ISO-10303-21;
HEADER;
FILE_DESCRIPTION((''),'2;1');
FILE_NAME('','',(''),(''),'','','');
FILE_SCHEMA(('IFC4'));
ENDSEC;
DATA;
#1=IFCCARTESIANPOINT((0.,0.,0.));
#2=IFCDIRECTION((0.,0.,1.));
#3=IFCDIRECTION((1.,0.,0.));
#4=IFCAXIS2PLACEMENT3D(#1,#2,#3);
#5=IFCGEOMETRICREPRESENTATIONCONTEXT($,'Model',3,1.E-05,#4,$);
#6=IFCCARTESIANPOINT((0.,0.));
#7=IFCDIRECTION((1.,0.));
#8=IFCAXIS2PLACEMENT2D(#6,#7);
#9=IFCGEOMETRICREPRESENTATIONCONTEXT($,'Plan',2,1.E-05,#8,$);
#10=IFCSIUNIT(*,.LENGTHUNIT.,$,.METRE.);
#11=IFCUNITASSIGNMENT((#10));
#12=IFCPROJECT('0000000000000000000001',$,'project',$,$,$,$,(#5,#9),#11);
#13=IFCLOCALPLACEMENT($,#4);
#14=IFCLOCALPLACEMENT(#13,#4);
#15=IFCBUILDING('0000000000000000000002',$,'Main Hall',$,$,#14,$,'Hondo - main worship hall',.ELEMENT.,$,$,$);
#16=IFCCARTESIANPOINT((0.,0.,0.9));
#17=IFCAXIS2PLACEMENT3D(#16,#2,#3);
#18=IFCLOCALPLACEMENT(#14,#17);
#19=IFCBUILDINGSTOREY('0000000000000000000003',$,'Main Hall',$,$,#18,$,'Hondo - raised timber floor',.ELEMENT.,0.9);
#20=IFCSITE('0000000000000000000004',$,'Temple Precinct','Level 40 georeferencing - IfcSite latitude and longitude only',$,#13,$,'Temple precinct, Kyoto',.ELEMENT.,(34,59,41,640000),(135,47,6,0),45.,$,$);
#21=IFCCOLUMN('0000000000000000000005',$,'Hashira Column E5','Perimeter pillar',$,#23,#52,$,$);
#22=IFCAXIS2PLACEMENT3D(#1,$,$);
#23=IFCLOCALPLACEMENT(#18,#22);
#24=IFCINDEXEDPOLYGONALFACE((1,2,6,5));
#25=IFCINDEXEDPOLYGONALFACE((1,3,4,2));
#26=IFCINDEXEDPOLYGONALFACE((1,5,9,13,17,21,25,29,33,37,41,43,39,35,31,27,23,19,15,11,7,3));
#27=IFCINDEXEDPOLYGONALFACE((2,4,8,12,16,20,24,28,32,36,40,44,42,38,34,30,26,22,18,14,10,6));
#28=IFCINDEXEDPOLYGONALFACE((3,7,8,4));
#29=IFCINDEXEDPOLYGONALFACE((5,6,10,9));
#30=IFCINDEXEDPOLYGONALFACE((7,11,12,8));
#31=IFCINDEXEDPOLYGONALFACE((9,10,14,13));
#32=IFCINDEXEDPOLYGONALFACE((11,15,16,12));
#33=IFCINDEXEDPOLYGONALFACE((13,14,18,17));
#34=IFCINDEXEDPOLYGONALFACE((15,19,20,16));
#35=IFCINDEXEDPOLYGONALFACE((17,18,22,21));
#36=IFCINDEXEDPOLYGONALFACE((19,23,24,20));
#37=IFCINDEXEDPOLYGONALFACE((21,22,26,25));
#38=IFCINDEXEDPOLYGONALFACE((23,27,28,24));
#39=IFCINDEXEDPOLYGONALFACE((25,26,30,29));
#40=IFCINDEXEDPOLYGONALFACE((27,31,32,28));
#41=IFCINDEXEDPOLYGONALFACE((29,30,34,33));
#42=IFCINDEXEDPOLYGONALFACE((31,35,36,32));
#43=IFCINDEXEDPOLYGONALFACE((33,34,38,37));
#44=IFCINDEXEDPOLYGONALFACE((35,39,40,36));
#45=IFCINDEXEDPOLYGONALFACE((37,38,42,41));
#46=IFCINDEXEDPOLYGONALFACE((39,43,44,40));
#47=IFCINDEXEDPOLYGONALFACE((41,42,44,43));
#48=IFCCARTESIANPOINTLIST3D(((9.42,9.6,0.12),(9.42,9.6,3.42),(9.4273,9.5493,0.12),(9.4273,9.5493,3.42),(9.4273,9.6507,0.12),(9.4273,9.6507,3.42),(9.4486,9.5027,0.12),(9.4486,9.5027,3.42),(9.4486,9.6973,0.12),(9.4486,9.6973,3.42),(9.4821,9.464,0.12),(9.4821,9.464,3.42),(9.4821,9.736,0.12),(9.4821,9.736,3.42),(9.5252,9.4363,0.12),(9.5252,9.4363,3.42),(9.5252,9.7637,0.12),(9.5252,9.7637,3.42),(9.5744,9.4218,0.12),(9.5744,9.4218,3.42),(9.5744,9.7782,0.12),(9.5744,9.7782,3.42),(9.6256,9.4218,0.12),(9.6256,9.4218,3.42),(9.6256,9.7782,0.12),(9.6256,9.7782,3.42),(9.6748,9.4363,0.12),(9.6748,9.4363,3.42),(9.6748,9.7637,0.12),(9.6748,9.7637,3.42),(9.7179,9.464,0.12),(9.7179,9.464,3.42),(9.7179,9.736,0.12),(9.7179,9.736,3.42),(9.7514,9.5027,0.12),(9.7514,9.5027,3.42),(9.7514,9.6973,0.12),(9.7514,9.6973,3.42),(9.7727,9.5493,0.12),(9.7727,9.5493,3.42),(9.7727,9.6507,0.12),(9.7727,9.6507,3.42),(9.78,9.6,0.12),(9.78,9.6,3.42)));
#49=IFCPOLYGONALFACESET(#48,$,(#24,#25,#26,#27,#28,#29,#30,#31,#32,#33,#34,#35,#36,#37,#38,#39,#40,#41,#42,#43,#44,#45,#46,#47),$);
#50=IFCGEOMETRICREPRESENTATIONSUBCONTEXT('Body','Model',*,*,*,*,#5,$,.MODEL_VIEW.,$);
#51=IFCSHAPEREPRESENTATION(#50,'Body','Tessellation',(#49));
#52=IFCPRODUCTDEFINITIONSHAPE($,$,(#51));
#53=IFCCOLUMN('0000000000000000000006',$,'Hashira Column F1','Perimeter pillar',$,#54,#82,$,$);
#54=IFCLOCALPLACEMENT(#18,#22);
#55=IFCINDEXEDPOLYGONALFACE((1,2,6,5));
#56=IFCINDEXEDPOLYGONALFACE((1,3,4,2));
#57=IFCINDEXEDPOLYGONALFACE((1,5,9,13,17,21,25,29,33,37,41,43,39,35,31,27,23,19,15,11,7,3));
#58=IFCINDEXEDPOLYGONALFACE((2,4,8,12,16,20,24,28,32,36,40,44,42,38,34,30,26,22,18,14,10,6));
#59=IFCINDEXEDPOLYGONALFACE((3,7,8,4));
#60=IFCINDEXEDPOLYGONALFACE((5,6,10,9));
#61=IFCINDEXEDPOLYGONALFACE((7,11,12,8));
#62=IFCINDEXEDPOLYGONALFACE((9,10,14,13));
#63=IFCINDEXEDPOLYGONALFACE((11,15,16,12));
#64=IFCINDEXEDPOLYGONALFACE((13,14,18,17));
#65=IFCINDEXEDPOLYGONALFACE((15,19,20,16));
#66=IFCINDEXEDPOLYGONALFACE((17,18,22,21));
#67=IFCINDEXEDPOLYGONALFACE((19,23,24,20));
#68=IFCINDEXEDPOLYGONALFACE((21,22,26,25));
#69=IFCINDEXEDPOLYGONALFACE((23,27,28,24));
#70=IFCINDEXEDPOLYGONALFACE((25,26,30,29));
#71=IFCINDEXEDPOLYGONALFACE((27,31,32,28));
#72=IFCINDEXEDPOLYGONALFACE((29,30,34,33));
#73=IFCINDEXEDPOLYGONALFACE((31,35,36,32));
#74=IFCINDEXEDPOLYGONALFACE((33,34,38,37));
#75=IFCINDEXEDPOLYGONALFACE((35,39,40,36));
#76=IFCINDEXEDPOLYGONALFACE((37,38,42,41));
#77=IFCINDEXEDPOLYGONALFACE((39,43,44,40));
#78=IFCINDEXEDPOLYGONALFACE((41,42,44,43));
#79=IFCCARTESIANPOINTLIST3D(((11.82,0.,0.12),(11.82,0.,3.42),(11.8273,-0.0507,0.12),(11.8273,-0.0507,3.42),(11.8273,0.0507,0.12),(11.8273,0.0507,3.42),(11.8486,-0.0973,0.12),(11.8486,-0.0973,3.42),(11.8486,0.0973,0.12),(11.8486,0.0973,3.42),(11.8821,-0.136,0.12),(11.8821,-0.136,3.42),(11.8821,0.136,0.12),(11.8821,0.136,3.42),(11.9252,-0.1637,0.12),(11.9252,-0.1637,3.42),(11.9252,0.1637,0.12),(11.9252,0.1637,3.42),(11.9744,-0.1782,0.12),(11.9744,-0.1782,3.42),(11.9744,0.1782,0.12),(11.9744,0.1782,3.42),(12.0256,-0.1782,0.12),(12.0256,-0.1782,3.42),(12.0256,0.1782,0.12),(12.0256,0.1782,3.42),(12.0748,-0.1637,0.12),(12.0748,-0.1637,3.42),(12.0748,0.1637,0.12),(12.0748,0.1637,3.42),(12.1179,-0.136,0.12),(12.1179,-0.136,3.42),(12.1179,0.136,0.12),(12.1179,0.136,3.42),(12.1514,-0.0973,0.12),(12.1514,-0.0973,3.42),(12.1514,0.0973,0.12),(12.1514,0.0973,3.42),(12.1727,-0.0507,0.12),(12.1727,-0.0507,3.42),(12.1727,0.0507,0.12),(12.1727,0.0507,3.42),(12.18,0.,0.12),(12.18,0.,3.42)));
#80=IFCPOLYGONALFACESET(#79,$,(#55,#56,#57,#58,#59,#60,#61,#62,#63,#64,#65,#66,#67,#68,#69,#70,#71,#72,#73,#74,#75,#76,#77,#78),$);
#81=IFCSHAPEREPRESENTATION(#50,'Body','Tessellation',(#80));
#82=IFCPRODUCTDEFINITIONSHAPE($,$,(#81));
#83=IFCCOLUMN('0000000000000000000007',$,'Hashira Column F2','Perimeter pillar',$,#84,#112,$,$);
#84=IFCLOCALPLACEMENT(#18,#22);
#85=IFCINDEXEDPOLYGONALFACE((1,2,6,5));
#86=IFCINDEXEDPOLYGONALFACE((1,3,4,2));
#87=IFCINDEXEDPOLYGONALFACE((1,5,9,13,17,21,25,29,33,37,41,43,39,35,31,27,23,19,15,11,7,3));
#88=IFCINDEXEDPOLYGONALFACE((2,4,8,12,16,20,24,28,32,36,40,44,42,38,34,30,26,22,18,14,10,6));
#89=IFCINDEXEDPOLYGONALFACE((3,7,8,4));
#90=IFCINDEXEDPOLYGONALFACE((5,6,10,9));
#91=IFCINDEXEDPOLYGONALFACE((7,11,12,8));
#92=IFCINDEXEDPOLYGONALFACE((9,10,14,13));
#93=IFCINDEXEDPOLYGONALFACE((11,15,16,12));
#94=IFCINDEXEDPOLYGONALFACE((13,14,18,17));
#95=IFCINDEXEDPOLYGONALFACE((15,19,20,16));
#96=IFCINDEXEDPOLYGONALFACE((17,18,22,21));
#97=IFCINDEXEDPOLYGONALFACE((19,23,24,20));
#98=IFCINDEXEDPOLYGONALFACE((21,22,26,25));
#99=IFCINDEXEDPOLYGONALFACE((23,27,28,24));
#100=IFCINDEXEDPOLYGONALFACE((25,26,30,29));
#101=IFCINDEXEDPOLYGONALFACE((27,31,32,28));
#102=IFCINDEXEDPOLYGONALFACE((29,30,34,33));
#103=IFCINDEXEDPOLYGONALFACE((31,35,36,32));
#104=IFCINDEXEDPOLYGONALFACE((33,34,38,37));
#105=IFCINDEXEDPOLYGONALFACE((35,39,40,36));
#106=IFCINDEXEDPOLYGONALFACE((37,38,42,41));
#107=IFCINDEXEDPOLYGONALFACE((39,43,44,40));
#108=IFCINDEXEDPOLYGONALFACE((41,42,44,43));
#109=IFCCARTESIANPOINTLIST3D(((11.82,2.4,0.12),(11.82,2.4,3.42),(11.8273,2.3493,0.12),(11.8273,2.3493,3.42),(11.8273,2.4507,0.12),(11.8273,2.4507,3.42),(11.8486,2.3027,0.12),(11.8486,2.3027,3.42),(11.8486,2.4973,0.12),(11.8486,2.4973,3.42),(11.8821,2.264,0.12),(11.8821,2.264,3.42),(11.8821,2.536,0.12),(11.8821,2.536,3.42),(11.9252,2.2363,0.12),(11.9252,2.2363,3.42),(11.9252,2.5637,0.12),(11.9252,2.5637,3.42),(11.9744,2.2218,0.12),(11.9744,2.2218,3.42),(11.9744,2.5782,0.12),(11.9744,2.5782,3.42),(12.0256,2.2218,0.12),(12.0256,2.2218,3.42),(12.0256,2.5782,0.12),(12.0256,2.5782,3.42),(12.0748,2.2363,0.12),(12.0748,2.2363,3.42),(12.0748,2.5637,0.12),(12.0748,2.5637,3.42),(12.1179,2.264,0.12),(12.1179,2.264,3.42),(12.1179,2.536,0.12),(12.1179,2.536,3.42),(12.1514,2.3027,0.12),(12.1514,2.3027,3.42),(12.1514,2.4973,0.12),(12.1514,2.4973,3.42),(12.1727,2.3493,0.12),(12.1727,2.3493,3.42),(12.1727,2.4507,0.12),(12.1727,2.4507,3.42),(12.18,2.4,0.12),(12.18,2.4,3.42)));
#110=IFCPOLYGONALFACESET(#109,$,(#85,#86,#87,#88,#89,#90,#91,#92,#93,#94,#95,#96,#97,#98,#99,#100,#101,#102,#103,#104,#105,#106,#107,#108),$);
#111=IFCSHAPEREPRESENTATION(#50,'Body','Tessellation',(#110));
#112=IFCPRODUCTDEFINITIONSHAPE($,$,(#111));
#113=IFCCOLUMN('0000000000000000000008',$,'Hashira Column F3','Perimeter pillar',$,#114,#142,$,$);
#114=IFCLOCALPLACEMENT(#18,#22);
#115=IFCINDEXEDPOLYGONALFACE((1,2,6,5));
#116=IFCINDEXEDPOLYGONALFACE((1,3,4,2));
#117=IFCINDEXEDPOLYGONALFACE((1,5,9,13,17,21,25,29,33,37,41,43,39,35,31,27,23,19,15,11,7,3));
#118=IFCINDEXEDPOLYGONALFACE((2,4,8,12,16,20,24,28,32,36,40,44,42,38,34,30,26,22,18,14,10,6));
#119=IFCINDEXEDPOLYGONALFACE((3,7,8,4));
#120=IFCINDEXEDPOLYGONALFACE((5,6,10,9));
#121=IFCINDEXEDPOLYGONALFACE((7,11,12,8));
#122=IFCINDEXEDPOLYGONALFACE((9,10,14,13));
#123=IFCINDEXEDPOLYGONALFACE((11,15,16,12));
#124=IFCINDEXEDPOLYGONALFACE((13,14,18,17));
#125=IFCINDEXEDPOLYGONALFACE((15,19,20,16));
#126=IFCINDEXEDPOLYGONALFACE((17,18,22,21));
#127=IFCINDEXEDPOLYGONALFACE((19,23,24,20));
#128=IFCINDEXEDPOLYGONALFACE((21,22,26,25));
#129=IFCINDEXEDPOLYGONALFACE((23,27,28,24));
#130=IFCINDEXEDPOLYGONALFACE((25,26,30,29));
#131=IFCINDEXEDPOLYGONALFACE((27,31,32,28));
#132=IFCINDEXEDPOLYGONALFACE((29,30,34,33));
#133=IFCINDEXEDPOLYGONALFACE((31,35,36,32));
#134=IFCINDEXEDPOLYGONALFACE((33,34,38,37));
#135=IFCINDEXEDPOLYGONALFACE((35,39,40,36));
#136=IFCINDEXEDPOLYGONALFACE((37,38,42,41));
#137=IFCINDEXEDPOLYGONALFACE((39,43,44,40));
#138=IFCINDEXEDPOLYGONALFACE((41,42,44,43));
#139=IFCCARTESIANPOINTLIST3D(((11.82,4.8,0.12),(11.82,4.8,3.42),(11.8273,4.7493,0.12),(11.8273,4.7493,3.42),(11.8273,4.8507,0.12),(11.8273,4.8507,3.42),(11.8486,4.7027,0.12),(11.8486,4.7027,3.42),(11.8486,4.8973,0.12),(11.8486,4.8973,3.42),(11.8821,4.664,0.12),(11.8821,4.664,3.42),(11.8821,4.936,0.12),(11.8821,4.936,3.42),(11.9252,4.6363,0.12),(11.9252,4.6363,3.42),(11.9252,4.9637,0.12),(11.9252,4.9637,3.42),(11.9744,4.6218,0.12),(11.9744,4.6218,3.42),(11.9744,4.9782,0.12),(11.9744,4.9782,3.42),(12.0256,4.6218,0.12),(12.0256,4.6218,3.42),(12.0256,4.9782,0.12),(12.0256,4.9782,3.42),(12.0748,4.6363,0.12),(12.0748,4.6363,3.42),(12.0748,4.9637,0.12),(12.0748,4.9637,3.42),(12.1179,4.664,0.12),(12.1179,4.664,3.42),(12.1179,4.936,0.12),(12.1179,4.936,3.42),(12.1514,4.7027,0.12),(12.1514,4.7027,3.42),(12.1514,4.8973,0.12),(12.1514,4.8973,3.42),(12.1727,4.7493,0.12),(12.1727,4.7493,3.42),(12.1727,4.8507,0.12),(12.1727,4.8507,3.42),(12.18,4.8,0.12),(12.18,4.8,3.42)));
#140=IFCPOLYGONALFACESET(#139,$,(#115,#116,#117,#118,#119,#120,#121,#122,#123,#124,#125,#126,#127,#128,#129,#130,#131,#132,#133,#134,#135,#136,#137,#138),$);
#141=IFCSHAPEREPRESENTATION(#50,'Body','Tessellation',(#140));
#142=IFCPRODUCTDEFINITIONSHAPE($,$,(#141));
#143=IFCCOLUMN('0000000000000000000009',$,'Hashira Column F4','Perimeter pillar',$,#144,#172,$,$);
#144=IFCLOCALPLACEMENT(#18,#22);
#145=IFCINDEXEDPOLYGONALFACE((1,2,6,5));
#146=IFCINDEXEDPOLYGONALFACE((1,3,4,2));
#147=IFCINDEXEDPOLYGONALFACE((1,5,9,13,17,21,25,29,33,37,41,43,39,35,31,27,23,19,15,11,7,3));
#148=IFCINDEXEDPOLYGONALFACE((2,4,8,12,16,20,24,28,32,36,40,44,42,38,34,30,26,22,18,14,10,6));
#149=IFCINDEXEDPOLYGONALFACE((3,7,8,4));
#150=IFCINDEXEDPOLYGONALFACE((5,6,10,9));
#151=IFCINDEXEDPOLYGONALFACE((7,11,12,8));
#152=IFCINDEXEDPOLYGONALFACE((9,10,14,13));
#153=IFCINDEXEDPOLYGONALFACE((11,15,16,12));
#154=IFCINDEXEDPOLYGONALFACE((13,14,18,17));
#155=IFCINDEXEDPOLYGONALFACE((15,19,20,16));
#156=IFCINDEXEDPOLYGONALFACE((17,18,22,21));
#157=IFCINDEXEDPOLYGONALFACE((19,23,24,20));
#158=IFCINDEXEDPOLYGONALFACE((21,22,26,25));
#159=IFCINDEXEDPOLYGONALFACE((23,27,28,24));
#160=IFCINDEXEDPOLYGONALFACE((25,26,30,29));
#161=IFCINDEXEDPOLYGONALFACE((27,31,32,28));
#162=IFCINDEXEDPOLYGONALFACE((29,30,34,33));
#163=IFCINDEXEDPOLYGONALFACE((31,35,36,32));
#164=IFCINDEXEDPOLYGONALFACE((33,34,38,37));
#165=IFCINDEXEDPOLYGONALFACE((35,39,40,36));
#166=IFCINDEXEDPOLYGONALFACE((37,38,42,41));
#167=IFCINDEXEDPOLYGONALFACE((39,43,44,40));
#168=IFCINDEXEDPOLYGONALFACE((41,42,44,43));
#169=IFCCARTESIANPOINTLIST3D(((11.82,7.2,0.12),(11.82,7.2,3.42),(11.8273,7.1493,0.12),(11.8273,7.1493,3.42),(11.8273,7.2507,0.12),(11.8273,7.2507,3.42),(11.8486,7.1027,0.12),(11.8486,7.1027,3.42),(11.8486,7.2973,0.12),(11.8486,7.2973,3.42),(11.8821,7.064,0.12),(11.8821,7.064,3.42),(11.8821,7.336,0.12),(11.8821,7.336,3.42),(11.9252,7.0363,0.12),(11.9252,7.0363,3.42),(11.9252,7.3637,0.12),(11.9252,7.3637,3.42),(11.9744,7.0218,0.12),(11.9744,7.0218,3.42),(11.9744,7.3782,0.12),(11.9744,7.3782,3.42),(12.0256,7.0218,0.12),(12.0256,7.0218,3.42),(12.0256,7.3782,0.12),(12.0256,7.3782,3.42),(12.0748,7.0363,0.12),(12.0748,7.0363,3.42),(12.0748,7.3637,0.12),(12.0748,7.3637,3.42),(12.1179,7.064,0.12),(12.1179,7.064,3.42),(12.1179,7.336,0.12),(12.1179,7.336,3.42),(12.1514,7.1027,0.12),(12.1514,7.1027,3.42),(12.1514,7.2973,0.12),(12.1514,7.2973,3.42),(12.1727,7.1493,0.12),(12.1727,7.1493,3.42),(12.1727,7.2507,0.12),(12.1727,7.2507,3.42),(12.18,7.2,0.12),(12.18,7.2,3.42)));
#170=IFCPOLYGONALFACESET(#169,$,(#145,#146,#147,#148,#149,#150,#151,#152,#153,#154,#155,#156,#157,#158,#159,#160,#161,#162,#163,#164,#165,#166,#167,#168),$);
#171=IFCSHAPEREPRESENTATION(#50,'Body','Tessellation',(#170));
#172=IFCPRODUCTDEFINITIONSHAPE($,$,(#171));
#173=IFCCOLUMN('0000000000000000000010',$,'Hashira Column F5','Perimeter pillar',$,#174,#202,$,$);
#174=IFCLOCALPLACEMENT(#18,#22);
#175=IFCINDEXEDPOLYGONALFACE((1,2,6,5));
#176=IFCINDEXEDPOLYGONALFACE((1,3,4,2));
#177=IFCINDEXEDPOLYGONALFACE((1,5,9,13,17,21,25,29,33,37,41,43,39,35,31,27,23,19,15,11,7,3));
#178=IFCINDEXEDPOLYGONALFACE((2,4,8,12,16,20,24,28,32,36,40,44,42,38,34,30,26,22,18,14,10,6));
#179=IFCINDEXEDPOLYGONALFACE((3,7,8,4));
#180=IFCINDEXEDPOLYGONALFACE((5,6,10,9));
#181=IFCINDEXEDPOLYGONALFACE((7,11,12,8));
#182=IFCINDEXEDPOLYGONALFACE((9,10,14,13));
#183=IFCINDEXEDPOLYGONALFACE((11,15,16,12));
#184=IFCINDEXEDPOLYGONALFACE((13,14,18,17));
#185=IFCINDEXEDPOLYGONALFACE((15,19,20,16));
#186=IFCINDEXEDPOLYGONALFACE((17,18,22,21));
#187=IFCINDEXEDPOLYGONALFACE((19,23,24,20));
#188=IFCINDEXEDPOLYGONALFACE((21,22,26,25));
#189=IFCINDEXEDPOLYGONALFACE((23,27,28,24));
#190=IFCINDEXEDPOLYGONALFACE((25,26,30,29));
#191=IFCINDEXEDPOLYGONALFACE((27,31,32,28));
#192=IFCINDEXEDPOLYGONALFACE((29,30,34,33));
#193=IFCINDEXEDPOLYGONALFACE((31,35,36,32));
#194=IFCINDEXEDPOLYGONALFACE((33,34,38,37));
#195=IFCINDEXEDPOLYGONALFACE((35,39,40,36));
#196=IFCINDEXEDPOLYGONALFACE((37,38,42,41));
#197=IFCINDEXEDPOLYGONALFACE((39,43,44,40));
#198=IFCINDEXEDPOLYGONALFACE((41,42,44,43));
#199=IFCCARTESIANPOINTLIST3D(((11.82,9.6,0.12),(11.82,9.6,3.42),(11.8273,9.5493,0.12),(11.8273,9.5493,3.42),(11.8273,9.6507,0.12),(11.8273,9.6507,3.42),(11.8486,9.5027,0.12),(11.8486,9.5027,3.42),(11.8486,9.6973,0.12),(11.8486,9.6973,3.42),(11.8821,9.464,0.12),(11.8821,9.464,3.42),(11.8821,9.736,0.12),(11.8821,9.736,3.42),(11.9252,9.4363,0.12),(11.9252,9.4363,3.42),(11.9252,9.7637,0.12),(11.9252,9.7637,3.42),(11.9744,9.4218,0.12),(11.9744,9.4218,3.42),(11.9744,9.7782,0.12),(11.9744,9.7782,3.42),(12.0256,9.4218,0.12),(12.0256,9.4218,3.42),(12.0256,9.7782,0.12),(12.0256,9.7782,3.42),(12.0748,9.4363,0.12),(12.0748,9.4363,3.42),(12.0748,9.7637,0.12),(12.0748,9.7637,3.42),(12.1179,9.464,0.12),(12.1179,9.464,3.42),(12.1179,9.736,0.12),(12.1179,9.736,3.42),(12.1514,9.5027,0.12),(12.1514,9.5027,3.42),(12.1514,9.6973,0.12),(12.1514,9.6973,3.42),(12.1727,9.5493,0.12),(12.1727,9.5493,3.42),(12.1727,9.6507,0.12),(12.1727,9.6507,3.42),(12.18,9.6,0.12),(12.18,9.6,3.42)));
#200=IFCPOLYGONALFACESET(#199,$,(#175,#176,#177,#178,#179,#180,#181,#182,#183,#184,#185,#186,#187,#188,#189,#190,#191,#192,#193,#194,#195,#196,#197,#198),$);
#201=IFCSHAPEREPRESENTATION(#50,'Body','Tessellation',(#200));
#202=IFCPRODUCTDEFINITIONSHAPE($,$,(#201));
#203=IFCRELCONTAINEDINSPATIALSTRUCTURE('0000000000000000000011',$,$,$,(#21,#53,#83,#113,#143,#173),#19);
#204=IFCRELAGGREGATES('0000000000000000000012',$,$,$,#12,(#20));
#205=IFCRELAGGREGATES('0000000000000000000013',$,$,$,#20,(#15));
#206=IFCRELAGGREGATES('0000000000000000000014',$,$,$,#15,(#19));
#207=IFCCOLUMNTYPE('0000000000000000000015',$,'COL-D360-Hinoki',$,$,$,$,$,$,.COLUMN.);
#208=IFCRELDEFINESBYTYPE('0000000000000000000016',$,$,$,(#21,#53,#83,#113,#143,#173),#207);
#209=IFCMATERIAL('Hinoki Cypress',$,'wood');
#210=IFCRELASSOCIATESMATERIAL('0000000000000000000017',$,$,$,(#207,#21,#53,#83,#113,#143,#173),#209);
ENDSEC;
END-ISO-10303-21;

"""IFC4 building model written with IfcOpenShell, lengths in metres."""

from ifc_helpers import new_model, si_unit, frame, origin_with_axes, origin_2d_with_axis, place, context, subcontext, project, spatial, circle, extrude, material, material_profile, profile_set, profile_usage, type_object, element, save


model = new_model("IFC4")

# Units and contexts
model_context = context("Model", 3, precision=1e-05, world=origin_with_axes())
plan_context = context("Plan", 2, precision=1e-05, world=origin_2d_with_axis())
body_context = subcontext(model_context, "Body", "Model", "MODEL_VIEW")
ifc_project = project(units=[si_unit("LENGTHUNIT", "METRE")], contexts=[model_context, plan_context])

# Site, building, storey
site_placement = place(None, origin_with_axes())
site = spatial("IfcSite", under=ifc_project, at=site_placement, Name="Temple Precinct", Description="Level 40 georeferencing - IfcSite latitude and longitude only", LongName="Temple precinct, Kyoto", CompositionType="ELEMENT", RefLatitude=(34, 59, 41, 640000), RefLongitude=(135, 47, 6, 0), RefElevation=45.0)
building_placement = place(site_placement, origin_with_axes())
building = spatial("IfcBuilding", under=site, at=building_placement, Name="Main Hall", LongName="Hondo - main worship hall", CompositionType="ELEMENT")
storey_placement = place(building_placement, frame((0.0, 0.0, 0.9), z_axis=(0.0, 0.0, 1.0), x_axis=(1.0, 0.0, 0.0)))
storey = spatial("IfcBuildingStorey", under=building, at=storey_placement, Name="Main Hall", LongName="Hondo - raised timber floor", CompositionType="ELEMENT", Elevation=0.9)

# Columns
ifc_material_1 = material(Name="Hinoki Cypress", Category="wood")
ifc_material_profile = material_profile(ifc_material_1, circle(Radius=0.18))
ifc_profile_set = profile_set([ifc_material_profile], Name="COL-D360-Hinoki")
column_type = type_object("IfcColumnType", Name="COL-D360-Hinoki", PredefinedType="COLUMN", material=ifc_profile_set)
ifc_profile_usage_1 = profile_usage(ifc_profile_set)
column_1_placement = place(storey_placement, frame((9.6, 9.6, 0.12), z_axis=(0.0, 0.0, 1.0), x_axis=(1.0, 0.0, 0.0)))
element("IfcColumn", 1, at=column_1_placement, inside=storey, type_object=column_type, material=ifc_profile_usage_1, Name="Hashira Column E5", Description="Perimeter pillar", context=body_context, shape_type="SweptSolid", body=[
    extrude(circle(Radius=0.18), origin_with_axes(), (0.0, 0.0, 1.0), 3.3),
])
ifc_profile_usage_2 = profile_usage(ifc_profile_set)
column_2_placement = place(storey_placement, frame((12.0, 0.0, 0.12), z_axis=(0.0, 0.0, 1.0), x_axis=(1.0, 0.0, 0.0)))
element("IfcColumn", 2, at=column_2_placement, inside=storey, type_object=column_type, material=ifc_profile_usage_2, Name="Hashira Column F1", Description="Perimeter pillar", context=body_context, shape_type="SweptSolid", body=[
    extrude(circle(Radius=0.18), origin_with_axes(), (0.0, 0.0, 1.0), 3.3),
])
ifc_profile_usage_3 = profile_usage(ifc_profile_set)
column_3_placement = place(storey_placement, frame((12.0, 2.4, 0.12), z_axis=(0.0, 0.0, 1.0), x_axis=(1.0, 0.0, 0.0)))
element("IfcColumn", 3, at=column_3_placement, inside=storey, type_object=column_type, material=ifc_profile_usage_3, Name="Hashira Column F2", Description="Perimeter pillar", context=body_context, shape_type="SweptSolid", body=[
    extrude(circle(Radius=0.18), origin_with_axes(), (0.0, 0.0, 1.0), 3.3),
])
ifc_profile_usage_4 = profile_usage(ifc_profile_set)
column_4_placement = place(storey_placement, frame((12.0, 4.8, 0.12), z_axis=(0.0, 0.0, 1.0), x_axis=(1.0, 0.0, 0.0)))
element("IfcColumn", 4, at=column_4_placement, inside=storey, type_object=column_type, material=ifc_profile_usage_4, Name="Hashira Column F3", Description="Perimeter pillar", context=body_context, shape_type="SweptSolid", body=[
    extrude(circle(Radius=0.18), origin_with_axes(), (0.0, 0.0, 1.0), 3.3),
])
ifc_profile_usage_5 = profile_usage(ifc_profile_set)
column_5_placement = place(storey_placement, frame((12.0, 7.2, 0.12), z_axis=(0.0, 0.0, 1.0), x_axis=(1.0, 0.0, 0.0)))
element("IfcColumn", 5, at=column_5_placement, inside=storey, type_object=column_type, material=ifc_profile_usage_5, Name="Hashira Column F4", Description="Perimeter pillar", context=body_context, shape_type="SweptSolid", body=[
    extrude(circle(Radius=0.18), origin_with_axes(), (0.0, 0.0, 1.0), 3.3),
])
ifc_profile_usage_6 = profile_usage(ifc_profile_set)
column_6_placement = place(storey_placement, frame((12.0, 9.6, 0.12), z_axis=(0.0, 0.0, 1.0), x_axis=(1.0, 0.0, 0.0)))
element("IfcColumn", 6, at=column_6_placement, inside=storey, type_object=column_type, material=ifc_profile_usage_6, Name="Hashira Column F5", Description="Perimeter pillar", context=body_context, shape_type="SweptSolid", body=[
    extrude(circle(Radius=0.18), origin_with_axes(), (0.0, 0.0, 1.0), 3.3),
])

save(model, "model.ifc")
